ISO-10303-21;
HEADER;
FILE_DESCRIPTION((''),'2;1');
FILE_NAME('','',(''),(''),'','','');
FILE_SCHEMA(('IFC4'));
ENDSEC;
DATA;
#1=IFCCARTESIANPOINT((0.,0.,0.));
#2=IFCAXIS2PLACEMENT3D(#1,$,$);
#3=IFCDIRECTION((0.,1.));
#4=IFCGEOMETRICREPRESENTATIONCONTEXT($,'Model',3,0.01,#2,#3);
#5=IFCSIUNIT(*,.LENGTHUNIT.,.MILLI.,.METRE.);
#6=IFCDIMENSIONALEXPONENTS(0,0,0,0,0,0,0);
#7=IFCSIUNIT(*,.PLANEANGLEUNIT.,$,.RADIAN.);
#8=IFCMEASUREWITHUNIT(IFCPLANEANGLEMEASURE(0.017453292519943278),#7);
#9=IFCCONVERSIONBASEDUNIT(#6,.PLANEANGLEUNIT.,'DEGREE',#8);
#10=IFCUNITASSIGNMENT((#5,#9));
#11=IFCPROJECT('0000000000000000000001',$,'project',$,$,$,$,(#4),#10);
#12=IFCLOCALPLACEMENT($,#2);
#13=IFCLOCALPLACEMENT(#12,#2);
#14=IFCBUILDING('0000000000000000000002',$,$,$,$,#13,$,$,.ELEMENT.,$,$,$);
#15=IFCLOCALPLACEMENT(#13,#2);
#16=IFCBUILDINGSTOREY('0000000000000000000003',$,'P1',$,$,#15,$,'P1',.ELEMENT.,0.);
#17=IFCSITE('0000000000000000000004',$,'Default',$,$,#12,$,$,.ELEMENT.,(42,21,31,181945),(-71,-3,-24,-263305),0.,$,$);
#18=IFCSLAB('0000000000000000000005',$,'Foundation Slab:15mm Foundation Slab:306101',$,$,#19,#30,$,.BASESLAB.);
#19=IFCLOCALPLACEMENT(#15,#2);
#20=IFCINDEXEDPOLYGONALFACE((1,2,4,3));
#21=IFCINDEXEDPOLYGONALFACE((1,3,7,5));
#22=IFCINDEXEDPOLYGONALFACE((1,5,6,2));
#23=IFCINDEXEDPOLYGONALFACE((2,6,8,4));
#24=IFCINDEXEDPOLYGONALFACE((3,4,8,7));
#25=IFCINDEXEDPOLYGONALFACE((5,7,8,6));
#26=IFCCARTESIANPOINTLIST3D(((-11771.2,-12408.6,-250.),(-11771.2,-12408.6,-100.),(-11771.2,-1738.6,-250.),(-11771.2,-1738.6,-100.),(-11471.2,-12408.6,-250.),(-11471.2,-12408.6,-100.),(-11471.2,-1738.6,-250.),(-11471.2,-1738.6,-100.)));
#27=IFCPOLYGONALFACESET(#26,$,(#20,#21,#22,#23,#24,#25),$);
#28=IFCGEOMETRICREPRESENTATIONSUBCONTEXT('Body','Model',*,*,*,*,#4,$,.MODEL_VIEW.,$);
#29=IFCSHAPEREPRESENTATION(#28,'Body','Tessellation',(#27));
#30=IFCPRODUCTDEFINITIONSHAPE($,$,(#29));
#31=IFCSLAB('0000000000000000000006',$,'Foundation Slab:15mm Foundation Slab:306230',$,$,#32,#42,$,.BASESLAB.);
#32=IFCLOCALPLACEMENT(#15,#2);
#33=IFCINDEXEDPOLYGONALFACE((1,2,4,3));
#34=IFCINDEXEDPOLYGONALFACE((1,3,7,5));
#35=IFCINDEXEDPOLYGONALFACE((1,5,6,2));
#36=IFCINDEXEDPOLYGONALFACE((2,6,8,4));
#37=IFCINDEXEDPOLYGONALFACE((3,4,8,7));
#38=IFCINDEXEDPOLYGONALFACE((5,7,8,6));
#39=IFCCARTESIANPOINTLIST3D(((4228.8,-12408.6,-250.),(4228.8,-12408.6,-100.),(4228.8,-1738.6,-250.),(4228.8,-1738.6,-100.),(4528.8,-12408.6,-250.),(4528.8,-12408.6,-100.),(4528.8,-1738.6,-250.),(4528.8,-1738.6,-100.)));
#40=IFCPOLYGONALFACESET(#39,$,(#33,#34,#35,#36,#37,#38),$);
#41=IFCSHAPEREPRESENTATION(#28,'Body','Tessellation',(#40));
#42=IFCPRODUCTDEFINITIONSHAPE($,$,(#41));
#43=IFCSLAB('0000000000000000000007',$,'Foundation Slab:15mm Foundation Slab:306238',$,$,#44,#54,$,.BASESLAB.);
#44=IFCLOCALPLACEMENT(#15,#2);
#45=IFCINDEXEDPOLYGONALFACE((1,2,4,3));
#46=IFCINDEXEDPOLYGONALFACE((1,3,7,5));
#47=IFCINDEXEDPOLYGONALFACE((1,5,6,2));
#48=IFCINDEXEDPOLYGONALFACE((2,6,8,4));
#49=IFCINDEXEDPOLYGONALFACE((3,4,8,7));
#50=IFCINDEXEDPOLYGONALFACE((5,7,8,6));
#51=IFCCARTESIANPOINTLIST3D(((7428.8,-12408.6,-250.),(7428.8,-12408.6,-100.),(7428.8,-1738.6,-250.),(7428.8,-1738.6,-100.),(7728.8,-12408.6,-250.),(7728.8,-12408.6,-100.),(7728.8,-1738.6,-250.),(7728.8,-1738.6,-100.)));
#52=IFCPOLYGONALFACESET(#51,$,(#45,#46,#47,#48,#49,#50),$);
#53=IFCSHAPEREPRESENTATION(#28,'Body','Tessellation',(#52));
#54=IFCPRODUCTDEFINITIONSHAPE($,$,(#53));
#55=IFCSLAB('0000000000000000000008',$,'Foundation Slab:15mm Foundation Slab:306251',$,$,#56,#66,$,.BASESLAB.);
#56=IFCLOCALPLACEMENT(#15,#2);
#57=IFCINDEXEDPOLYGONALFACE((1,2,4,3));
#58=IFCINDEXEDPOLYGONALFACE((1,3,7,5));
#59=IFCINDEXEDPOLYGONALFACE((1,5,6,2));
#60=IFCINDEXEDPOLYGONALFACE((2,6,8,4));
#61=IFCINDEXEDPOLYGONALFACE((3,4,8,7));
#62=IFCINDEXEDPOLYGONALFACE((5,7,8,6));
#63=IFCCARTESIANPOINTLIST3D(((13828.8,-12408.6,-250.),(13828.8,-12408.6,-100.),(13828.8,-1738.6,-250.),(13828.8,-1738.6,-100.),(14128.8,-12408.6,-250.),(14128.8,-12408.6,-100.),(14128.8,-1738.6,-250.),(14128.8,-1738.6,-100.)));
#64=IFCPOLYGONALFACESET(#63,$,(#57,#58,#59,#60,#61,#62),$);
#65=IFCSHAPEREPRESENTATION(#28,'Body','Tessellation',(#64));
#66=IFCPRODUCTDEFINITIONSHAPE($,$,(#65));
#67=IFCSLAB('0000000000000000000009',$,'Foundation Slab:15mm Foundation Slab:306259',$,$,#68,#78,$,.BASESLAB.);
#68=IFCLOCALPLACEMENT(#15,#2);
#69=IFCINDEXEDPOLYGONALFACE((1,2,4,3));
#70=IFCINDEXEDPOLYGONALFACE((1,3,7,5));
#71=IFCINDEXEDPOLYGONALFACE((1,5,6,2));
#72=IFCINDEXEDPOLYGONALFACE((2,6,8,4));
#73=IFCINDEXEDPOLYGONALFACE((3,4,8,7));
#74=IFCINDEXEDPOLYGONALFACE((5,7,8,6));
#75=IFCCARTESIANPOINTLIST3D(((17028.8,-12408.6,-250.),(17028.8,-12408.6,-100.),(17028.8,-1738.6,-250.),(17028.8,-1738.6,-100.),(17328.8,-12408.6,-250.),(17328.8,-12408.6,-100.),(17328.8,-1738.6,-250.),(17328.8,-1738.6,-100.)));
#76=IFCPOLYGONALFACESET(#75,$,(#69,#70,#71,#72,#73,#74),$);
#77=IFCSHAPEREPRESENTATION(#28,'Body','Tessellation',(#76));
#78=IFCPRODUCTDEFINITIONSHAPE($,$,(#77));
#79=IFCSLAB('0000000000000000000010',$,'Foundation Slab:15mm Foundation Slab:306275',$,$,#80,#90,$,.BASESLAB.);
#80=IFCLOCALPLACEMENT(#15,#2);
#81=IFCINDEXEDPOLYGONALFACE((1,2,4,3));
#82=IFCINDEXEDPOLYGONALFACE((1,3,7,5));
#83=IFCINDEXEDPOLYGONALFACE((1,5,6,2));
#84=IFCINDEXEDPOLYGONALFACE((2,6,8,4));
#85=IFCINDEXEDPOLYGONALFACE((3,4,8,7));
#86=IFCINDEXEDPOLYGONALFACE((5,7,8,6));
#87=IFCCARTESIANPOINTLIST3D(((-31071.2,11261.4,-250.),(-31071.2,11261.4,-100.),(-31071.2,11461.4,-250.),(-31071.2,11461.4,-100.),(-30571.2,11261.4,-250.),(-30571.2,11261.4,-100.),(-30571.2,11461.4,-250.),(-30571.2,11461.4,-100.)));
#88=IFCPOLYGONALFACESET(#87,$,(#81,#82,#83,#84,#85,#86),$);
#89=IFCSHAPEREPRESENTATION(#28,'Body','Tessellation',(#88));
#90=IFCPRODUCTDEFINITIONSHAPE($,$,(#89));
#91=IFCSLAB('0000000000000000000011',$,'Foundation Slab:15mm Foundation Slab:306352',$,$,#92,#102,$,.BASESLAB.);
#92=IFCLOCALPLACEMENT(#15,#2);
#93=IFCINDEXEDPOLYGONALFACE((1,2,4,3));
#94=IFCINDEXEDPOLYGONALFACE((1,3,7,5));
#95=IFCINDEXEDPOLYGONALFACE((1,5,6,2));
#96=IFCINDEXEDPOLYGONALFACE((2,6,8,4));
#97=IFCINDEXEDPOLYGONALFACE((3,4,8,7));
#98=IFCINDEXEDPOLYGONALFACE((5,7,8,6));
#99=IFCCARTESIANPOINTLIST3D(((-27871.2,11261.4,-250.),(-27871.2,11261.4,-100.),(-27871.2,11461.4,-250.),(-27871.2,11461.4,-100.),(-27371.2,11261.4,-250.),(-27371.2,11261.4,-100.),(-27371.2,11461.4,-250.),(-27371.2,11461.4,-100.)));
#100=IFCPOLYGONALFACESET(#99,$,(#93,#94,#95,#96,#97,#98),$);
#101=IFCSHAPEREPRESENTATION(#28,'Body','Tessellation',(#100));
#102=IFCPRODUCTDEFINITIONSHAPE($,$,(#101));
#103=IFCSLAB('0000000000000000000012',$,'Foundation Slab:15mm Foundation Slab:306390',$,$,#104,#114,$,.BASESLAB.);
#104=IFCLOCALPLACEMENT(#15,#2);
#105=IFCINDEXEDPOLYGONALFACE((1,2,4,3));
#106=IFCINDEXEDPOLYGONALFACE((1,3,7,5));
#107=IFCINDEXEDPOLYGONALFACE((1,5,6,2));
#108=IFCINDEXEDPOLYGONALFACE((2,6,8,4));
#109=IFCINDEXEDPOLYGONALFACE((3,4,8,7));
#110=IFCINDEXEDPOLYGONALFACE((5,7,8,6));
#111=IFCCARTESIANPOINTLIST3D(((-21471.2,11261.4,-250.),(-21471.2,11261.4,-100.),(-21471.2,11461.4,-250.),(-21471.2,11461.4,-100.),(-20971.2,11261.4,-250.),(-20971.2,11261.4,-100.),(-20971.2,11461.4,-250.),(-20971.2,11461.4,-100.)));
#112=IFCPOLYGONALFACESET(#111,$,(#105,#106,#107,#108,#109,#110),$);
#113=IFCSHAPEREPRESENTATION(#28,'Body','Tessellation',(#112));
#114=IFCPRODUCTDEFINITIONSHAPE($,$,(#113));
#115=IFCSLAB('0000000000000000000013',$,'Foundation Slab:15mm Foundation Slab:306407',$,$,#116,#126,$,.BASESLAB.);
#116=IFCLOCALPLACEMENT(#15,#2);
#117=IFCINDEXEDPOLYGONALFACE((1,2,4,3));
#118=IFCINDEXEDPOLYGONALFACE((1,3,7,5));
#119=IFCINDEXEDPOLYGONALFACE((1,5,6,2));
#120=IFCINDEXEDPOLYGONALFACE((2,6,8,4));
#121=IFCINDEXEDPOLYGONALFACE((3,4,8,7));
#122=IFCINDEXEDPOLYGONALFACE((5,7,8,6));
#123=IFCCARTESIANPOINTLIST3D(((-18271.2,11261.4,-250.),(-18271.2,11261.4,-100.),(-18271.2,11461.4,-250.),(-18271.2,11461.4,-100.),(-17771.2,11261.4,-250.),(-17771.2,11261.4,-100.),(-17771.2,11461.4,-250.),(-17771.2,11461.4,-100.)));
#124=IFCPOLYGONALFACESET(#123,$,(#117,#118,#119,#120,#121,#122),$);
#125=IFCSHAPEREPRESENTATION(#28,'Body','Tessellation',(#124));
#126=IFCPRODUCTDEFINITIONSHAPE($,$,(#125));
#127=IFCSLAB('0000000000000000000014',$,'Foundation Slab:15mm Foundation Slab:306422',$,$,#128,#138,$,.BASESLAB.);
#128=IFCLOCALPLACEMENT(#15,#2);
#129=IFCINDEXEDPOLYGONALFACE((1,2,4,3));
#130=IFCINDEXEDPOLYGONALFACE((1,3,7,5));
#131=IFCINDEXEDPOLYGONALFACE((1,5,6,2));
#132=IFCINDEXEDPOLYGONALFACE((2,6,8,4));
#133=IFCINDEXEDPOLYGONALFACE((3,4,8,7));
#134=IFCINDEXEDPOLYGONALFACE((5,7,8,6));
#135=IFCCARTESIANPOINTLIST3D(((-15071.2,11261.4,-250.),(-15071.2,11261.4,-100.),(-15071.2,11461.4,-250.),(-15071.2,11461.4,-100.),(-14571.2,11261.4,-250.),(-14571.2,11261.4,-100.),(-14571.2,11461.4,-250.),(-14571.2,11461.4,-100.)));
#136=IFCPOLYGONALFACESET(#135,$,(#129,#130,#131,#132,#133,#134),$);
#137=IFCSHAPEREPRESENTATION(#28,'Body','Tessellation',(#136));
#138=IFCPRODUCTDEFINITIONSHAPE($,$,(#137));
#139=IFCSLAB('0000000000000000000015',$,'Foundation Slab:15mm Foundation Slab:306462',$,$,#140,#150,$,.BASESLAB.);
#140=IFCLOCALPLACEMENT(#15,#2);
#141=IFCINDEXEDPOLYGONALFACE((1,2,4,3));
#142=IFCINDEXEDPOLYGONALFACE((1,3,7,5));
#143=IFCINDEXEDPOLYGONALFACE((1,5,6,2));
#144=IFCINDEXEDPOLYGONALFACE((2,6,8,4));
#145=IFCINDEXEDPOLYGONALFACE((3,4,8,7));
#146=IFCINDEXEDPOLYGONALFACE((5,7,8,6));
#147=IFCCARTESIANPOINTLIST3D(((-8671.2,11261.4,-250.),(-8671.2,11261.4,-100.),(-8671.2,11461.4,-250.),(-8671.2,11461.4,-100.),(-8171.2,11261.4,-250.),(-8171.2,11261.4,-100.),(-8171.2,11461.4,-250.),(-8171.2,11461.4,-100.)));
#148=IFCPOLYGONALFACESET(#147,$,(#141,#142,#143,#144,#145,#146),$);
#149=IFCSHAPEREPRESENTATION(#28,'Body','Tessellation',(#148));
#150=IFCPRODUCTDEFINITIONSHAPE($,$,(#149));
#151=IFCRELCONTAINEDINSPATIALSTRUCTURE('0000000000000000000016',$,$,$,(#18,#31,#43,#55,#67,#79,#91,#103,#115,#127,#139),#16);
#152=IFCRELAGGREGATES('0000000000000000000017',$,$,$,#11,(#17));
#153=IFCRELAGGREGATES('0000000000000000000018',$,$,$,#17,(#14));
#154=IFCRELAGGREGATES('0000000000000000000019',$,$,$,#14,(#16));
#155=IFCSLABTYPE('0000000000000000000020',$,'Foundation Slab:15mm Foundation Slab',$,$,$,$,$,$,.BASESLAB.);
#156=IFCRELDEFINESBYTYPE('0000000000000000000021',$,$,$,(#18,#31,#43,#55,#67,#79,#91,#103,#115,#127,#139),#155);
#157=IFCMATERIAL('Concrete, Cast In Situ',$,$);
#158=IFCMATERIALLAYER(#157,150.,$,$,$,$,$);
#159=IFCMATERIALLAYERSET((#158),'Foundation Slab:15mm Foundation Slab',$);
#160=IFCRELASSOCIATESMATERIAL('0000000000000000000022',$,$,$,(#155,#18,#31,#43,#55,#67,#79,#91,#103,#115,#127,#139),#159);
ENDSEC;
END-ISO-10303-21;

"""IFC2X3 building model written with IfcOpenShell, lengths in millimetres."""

from ifc_helpers import new_model, entity, si_unit, converted_unit, direction, frame, frame_2d, origin, origin_2d_with_axis, place, context, subcontext, project, spatial, rectangle, extrude, material, layer, layer_set, layer_usage, type_object, element, save


model = new_model("IFC2X3")

# Units and contexts
model_context = context("Model", 3, precision=0.01, world=origin(), true_north=direction((0.0, 1.0)))
body_context = subcontext(model_context, "Body", "Model", "MODEL_VIEW")
ifc_project = project(units=[si_unit("LENGTHUNIT", "METRE", prefix="MILLI"), converted_unit("PLANEANGLEUNIT", "DEGREE", entity("IfcPlaneAngleMeasure", 0.017453292519943278), si_unit("PLANEANGLEUNIT", "RADIAN"), dimensions=[0, 0, 0, 0, 0, 0, 0])], contexts=[model_context])

# Site, building, storey
site_placement = place(None, origin())
site = spatial("IfcSite", under=ifc_project, at=site_placement, Name="Default", CompositionType="ELEMENT", RefLatitude=(42, 21, 31, 181945), RefLongitude=(-71, -3, -24, -263305), RefElevation=0.0)
building_placement = place(site_placement, origin())
building = spatial("IfcBuilding", under=site, at=building_placement, CompositionType="ELEMENT")
storey_placement = place(building_placement, origin())
storey = spatial("IfcBuildingStorey", under=building, at=storey_placement, Name="P1", LongName="P1", CompositionType="ELEMENT", Elevation=0.0)

# Slabs
ifc_material_1 = material(Name="Concrete, Cast In Situ")
ifc_layer = layer(ifc_material_1, 150.0)
ifc_layer_set = layer_set([ifc_layer], Name="Foundation Slab:15mm Foundation Slab")
slab_type = type_object("IfcSlabType", Name="Foundation Slab:15mm Foundation Slab", PredefinedType="BASESLAB", material=ifc_layer_set)
ifc_layer_usage_1 = layer_usage(ifc_layer_set, "AXIS3", "POSITIVE", 0.0)
slab_1_placement = place(storey_placement, origin())
element("IfcSlab", 1, at=slab_1_placement, inside=storey, type_object=slab_type, material=ifc_layer_usage_1, Name="Foundation Slab:15mm Foundation Slab:306101", PredefinedType="BASESLAB", context=body_context, shape_type="SweptSolid", body=[
    extrude(rectangle(XDim=10670.0, YDim=300.0, at=origin_2d_with_axis()), frame((-11621.2, -7073.6, -100.0), z_axis=(0.0, 0.0, -1.0), x_axis=(0.0, 1.0, 0.0)), (0.0, 0.0, 1.0), 150.0),
])
ifc_layer_usage_2 = layer_usage(ifc_layer_set, "AXIS3", "POSITIVE", 0.0)
slab_2_placement = place(storey_placement, origin())
element("IfcSlab", 2, at=slab_2_placement, inside=storey, type_object=slab_type, material=ifc_layer_usage_2, Name="Foundation Slab:15mm Foundation Slab:306230", PredefinedType="BASESLAB", context=body_context, shape_type="SweptSolid", body=[
    extrude(rectangle(XDim=10670.0, YDim=300.0, at=origin_2d_with_axis()), frame((4378.8, -7073.6, -100.0), z_axis=(0.0, 0.0, -1.0), x_axis=(0.0, 1.0, 0.0)), (0.0, 0.0, 1.0), 150.0),
])
ifc_layer_usage_3 = layer_usage(ifc_layer_set, "AXIS3", "POSITIVE", 0.0)
slab_3_placement = place(storey_placement, origin())
element("IfcSlab", 3, at=slab_3_placement, inside=storey, type_object=slab_type, material=ifc_layer_usage_3, Name="Foundation Slab:15mm Foundation Slab:306238", PredefinedType="BASESLAB", context=body_context, shape_type="SweptSolid", body=[
    extrude(rectangle(XDim=10670.0, YDim=300.0, at=origin_2d_with_axis()), frame((7578.8, -7073.6, -100.0), z_axis=(0.0, 0.0, -1.0), x_axis=(0.0, 1.0, 0.0)), (0.0, 0.0, 1.0), 150.0),
])
ifc_layer_usage_4 = layer_usage(ifc_layer_set, "AXIS3", "POSITIVE", 0.0)
slab_4_placement = place(storey_placement, origin())
element("IfcSlab", 4, at=slab_4_placement, inside=storey, type_object=slab_type, material=ifc_layer_usage_4, Name="Foundation Slab:15mm Foundation Slab:306251", PredefinedType="BASESLAB", context=body_context, shape_type="SweptSolid", body=[
    extrude(rectangle(XDim=10670.0, YDim=300.0, at=origin_2d_with_axis()), frame((13978.8, -7073.6, -100.0), z_axis=(0.0, 0.0, -1.0), x_axis=(0.0, 1.0, 0.0)), (0.0, 0.0, 1.0), 150.0),
])
ifc_layer_usage_5 = layer_usage(ifc_layer_set, "AXIS3", "POSITIVE", 0.0)
slab_5_placement = place(storey_placement, origin())
element("IfcSlab", 5, at=slab_5_placement, inside=storey, type_object=slab_type, material=ifc_layer_usage_5, Name="Foundation Slab:15mm Foundation Slab:306259", PredefinedType="BASESLAB", context=body_context, shape_type="SweptSolid", body=[
    extrude(rectangle(XDim=10670.0, YDim=300.0, at=origin_2d_with_axis()), frame((17178.8, -7073.6, -100.0), z_axis=(0.0, 0.0, -1.0), x_axis=(0.0, 1.0, 0.0)), (0.0, 0.0, 1.0), 150.0),
])
ifc_layer_usage_6 = layer_usage(ifc_layer_set, "AXIS3", "POSITIVE", 0.0)
slab_6_placement = place(storey_placement, origin())
element("IfcSlab", 6, at=slab_6_placement, inside=storey, type_object=slab_type, material=ifc_layer_usage_6, Name="Foundation Slab:15mm Foundation Slab:306275", PredefinedType="BASESLAB", context=body_context, shape_type="SweptSolid", body=[
    extrude(rectangle(XDim=200.0, YDim=500.0, at=frame_2d((0.0, 0.0), x_axis=(1.0, 0.0))), frame((-30821.2, 11361.4, -100.0), z_axis=(0.0, 0.0, -1.0), x_axis=(0.0, 1.0, 0.0)), (0.0, 0.0, 1.0), 150.0),
])
ifc_layer_usage_7 = layer_usage(ifc_layer_set, "AXIS3", "POSITIVE", 0.0)
slab_7_placement = place(storey_placement, origin())
element("IfcSlab", 7, at=slab_7_placement, inside=storey, type_object=slab_type, material=ifc_layer_usage_7, Name="Foundation Slab:15mm Foundation Slab:306352", PredefinedType="BASESLAB", context=body_context, shape_type="SweptSolid", body=[
    extrude(rectangle(XDim=200.0, YDim=500.0, at=frame_2d((0.0, 0.0), x_axis=(1.0, 0.0))), frame((-27621.2, 11361.4, -100.0), z_axis=(0.0, 0.0, -1.0), x_axis=(0.0, 1.0, 0.0)), (0.0, 0.0, 1.0), 150.0),
])
ifc_layer_usage_8 = layer_usage(ifc_layer_set, "AXIS3", "POSITIVE", 0.0)
slab_8_placement = place(storey_placement, origin())
element("IfcSlab", 8, at=slab_8_placement, inside=storey, type_object=slab_type, material=ifc_layer_usage_8, Name="Foundation Slab:15mm Foundation Slab:306390", PredefinedType="BASESLAB", context=body_context, shape_type="SweptSolid", body=[
    extrude(rectangle(XDim=200.0, YDim=500.0, at=frame_2d((0.0, 0.0), x_axis=(1.0, 0.0))), frame((-21221.2, 11361.4, -100.0), z_axis=(0.0, 0.0, -1.0), x_axis=(0.0, 1.0, 0.0)), (0.0, 0.0, 1.0), 150.0),
])
ifc_layer_usage_9 = layer_usage(ifc_layer_set, "AXIS3", "POSITIVE", 0.0)
slab_9_placement = place(storey_placement, origin())
element("IfcSlab", 9, at=slab_9_placement, inside=storey, type_object=slab_type, material=ifc_layer_usage_9, Name="Foundation Slab:15mm Foundation Slab:306407", PredefinedType="BASESLAB", context=body_context, shape_type="SweptSolid", body=[
    extrude(rectangle(XDim=200.0, YDim=500.0, at=frame_2d((0.0, 0.0), x_axis=(1.0, 0.0))), frame((-18021.2, 11361.4, -100.0), z_axis=(0.0, 0.0, -1.0), x_axis=(0.0, 1.0, 0.0)), (0.0, 0.0, 1.0), 150.0),
])
ifc_layer_usage_10 = layer_usage(ifc_layer_set, "AXIS3", "POSITIVE", 0.0)
slab_10_placement = place(storey_placement, origin())
element("IfcSlab", 10, at=slab_10_placement, inside=storey, type_object=slab_type, material=ifc_layer_usage_10, Name="Foundation Slab:15mm Foundation Slab:306422", PredefinedType="BASESLAB", context=body_context, shape_type="SweptSolid", body=[
    extrude(rectangle(XDim=200.0, YDim=500.0, at=frame_2d((0.0, 0.0), x_axis=(1.0, 0.0))), frame((-14821.2, 11361.4, -100.0), z_axis=(0.0, 0.0, -1.0), x_axis=(0.0, 1.0, 0.0)), (0.0, 0.0, 1.0), 150.0),
])
ifc_layer_usage_11 = layer_usage(ifc_layer_set, "AXIS3", "POSITIVE", 0.0)
slab_11_placement = place(storey_placement, origin())
element("IfcSlab", 11, at=slab_11_placement, inside=storey, type_object=slab_type, material=ifc_layer_usage_11, Name="Foundation Slab:15mm Foundation Slab:306462", PredefinedType="BASESLAB", context=body_context, shape_type="SweptSolid", body=[
    extrude(rectangle(XDim=200.0, YDim=500.0, at=frame_2d((0.0, 0.0), x_axis=(1.0, 0.0))), frame((-8421.2, 11361.4, -100.0), z_axis=(0.0, 0.0, -1.0), x_axis=(0.0, 1.0, 0.0)), (0.0, 0.0, 1.0), 150.0),
])

save(model, "model.ifc")
